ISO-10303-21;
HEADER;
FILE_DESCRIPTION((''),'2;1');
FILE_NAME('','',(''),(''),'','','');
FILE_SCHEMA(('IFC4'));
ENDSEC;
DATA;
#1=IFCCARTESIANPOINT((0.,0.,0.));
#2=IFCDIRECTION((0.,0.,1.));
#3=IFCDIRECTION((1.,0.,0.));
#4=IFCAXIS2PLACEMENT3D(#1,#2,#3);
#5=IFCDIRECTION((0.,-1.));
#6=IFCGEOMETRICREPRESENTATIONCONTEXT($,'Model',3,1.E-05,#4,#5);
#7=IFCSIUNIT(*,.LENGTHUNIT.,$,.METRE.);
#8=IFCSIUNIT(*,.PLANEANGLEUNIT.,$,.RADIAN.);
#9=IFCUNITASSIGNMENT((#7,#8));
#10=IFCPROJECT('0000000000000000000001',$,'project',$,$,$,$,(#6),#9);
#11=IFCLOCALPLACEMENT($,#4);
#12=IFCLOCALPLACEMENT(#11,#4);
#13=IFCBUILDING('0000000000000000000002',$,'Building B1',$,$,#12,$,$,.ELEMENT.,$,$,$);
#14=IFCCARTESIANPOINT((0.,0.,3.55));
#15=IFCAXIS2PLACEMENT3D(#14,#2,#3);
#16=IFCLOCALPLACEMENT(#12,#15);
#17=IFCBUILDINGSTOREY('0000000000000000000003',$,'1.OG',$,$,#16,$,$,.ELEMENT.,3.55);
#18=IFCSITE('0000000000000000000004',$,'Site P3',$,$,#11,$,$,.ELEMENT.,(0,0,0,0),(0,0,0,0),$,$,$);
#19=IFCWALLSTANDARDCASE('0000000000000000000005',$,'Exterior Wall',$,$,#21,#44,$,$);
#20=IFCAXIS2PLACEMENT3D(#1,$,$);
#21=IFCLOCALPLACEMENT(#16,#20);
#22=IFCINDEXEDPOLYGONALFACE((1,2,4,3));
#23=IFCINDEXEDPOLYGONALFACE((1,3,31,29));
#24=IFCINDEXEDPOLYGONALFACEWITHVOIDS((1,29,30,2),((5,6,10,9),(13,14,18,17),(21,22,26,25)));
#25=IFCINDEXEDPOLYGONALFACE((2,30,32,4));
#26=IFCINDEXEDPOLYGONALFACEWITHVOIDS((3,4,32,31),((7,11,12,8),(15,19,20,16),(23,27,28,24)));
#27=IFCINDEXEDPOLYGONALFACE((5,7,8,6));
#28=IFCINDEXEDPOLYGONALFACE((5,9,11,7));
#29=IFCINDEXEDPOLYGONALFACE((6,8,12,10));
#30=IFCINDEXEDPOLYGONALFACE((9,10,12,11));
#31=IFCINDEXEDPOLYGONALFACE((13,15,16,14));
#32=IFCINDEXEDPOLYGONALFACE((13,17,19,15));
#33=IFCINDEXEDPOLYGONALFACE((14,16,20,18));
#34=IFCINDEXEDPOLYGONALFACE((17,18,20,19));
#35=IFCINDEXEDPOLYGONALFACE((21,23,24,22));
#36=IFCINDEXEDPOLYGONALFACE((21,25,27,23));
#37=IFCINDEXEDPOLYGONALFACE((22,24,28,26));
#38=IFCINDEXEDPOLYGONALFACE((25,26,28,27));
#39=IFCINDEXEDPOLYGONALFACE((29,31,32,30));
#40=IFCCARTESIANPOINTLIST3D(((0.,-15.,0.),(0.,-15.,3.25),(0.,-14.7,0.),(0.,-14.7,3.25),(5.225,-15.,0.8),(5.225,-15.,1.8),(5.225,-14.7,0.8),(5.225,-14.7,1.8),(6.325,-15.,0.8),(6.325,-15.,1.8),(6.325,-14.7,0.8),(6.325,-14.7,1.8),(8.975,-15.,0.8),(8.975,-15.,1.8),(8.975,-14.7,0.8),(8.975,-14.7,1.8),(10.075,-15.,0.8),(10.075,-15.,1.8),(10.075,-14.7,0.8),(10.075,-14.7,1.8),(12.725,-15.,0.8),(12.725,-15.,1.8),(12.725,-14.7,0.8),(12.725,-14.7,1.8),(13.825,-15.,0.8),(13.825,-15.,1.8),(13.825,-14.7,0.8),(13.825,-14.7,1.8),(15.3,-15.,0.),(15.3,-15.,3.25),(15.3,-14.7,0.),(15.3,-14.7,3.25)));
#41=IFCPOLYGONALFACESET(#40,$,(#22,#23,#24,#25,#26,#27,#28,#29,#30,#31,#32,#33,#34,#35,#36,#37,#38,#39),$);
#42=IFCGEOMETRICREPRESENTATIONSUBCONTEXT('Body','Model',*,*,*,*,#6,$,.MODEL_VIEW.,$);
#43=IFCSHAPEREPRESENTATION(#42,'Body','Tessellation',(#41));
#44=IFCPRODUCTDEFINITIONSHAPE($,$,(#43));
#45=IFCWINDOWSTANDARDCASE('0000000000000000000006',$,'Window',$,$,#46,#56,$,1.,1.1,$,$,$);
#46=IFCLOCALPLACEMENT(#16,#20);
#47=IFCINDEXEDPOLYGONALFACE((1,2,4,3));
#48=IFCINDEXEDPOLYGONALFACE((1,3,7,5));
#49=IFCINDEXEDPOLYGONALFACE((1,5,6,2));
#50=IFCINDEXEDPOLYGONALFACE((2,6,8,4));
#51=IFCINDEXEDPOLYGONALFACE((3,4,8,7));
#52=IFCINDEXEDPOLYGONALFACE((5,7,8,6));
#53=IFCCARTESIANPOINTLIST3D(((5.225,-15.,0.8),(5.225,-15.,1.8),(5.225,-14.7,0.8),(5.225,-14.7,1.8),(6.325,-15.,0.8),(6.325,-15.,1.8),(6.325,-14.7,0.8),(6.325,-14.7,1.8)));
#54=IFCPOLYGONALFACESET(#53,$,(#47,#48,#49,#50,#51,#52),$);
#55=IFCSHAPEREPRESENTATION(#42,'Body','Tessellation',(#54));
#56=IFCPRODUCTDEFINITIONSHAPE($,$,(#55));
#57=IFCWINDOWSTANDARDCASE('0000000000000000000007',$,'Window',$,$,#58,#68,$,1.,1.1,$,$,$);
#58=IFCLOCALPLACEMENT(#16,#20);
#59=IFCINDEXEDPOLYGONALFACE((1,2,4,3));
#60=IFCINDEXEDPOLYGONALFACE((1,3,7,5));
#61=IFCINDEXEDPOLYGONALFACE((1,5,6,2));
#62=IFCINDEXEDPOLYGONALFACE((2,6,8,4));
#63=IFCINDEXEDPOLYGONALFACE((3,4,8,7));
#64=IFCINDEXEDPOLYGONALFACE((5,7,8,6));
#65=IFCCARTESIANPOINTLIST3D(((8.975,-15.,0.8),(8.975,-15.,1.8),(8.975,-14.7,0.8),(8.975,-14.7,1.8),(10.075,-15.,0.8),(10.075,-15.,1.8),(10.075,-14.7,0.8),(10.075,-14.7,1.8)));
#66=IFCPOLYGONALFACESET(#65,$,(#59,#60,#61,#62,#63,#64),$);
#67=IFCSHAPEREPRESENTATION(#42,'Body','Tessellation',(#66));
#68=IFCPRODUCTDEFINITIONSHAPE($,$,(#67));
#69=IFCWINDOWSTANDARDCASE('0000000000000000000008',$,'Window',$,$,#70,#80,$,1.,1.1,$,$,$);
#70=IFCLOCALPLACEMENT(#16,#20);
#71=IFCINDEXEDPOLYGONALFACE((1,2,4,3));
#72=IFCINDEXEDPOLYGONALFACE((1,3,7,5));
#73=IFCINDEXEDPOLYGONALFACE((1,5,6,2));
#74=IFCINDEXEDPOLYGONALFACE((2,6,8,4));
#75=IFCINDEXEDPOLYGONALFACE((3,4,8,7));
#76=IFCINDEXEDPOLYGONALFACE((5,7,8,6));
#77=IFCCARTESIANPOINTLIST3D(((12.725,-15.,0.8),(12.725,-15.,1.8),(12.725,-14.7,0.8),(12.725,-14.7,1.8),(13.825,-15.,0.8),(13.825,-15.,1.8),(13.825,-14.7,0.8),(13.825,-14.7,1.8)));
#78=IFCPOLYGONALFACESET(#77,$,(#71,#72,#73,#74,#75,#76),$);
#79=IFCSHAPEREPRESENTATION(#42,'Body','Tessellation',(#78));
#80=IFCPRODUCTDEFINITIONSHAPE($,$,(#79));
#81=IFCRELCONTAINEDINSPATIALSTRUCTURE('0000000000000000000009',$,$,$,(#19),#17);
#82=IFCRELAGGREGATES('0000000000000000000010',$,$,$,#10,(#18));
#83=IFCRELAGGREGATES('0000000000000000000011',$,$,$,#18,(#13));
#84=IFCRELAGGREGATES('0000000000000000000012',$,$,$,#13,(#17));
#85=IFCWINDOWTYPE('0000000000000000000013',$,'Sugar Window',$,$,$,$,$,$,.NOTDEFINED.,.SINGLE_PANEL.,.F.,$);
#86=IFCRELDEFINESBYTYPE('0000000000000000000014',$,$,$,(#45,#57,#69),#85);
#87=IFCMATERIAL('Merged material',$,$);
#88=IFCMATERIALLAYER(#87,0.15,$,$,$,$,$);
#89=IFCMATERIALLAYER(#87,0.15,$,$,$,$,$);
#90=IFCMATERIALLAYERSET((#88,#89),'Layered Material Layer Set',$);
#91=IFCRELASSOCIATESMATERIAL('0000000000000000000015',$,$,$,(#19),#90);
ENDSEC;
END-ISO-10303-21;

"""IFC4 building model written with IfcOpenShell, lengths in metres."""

from ifc_helpers import new_model, si_unit, direction, frame, origin_with_axes, place, context, subcontext, project, spatial, polyline, outline, extrude, source, transform, mapped, material, layer, layer_set, layer_usage, type_object, element, fill, save


model = new_model("IFC4")

# Units and contexts
model_context = context("Model", 3, precision=1e-05, world=origin_with_axes(), true_north=direction((0.0, -1.0)))
body_context = subcontext(model_context, "Body", "Model", "MODEL_VIEW")
ifc_project = project(units=[si_unit("LENGTHUNIT", "METRE"), si_unit("PLANEANGLEUNIT", "RADIAN")], contexts=[model_context])

# Site, building, storey
site_placement = place(None, origin_with_axes())
site = spatial("IfcSite", under=ifc_project, at=site_placement, Name="Site P3", CompositionType="ELEMENT", RefLatitude=(0, 0, 0, 0), RefLongitude=(0, 0, 0, 0))
building_placement = place(site_placement, origin_with_axes())
building = spatial("IfcBuilding", under=site, at=building_placement, Name="Building B1", CompositionType="ELEMENT")
storey_placement = place(building_placement, frame((0.0, 0.0, 3.55), z_axis=(0.0, 0.0, 1.0), x_axis=(1.0, 0.0, 0.0)))
storey = spatial("IfcBuildingStorey", under=building, at=storey_placement, Name="1.OG", CompositionType="ELEMENT", Elevation=3.55)

# Wall, openings, windows
ifc_material = material(Name="Merged material")
ifc_layer_1 = layer(ifc_material, 0.15)
ifc_layer_2 = layer(ifc_material, 0.15)
ifc_layer_set_1 = layer_set([ifc_layer_1, ifc_layer_2], Name="Layered Material Layer Set")
ifc_layer_usage_1 = layer_usage(ifc_layer_set_1, "AXIS2", "POSITIVE", -0.15)
wall_1_placement = place(storey_placement, frame((0.0, -14.85, 0.0), z_axis=(0.0, 0.0, 1.0), x_axis=(1.0, 0.0, 0.0)))
wall_1 = element("IfcWallStandardCase", 1, at=wall_1_placement, inside=storey, material=ifc_layer_usage_1, Name="Exterior Wall", context=body_context, shape_type="SweptSolid", body=[
    extrude(outline(polyline([(0.0, 0.15), (15.3, 0.15), (15.3, -0.15), (0.0, -0.15), (0.0, 0.15)])), origin_with_axes(), (0.0, 0.0, 1.0), 3.25),
])
opening_1_placement = place(wall_1_placement, frame((5.225, 0.0, 0.8), z_axis=(0.0, 0.0, 1.0), x_axis=(1.0, 0.0, 0.0)))
opening_1 = element("IfcOpeningStandardCase", 2, at=opening_1_placement, cuts=wall_1, context=body_context, shape_type="SweptSolid", body=[
    extrude(outline(polyline([(0.0, 0.0), (0.0, 1.1), (1.0, 1.1), (1.0, 0.0), (0.0, 0.0)])), frame((0.0, -0.15, 0.0), z_axis=(0.0, 1.0, 0.0), x_axis=(0.0, 0.0, 1.0)), (0.0, 0.0, 1.0), 0.3),
])
opening_2_placement = place(wall_1_placement, frame((8.975, 0.0, 0.8), z_axis=(0.0, 0.0, 1.0), x_axis=(1.0, 0.0, 0.0)))
opening_2 = element("IfcOpeningStandardCase", 3, at=opening_2_placement, cuts=wall_1, context=body_context, shape_type="SweptSolid", body=[
    extrude(outline(polyline([(0.0, 0.0), (0.0, 1.1), (1.0, 1.1), (1.0, 0.0), (0.0, 0.0)])), frame((0.0, -0.15, 0.0), z_axis=(0.0, 1.0, 0.0), x_axis=(0.0, 0.0, 1.0)), (0.0, 0.0, 1.0), 0.3),
])
opening_3_placement = place(wall_1_placement, frame((12.725, 0.0, 0.8), z_axis=(0.0, 0.0, 1.0), x_axis=(1.0, 0.0, 0.0)))
opening_3 = element("IfcOpeningStandardCase", 4, at=opening_3_placement, cuts=wall_1, context=body_context, shape_type="SweptSolid", body=[
    extrude(outline(polyline([(0.0, 0.0), (0.0, 1.1), (1.0, 1.1), (1.0, 0.0), (0.0, 0.0)])), frame((0.0, -0.15, 0.0), z_axis=(0.0, 1.0, 0.0), x_axis=(0.0, 0.0, 1.0)), (0.0, 0.0, 1.0), 0.3),
])
window_type = type_object("IfcWindowType", Name="Sugar Window", ParameterTakesPrecedence=False, PartitioningType="SINGLE_PANEL", PredefinedType="NOTDEFINED")
shared_shape_1 = source(origin_with_axes(), body_context, "Body", "SweptSolid", [
    extrude(outline(polyline([(0.0, 0.0), (0.0, 1.1), (1.0, 1.1), (1.0, 0.0), (0.0, 0.0)])), frame((0.0, -0.15, 0.0), z_axis=(0.0, 1.0, 0.0), x_axis=(0.0, 0.0, 1.0)), (0.0, 0.0, 1.0), 0.3),
])
window_1_placement = place(opening_1_placement, origin_with_axes())
window_1 = element("IfcWindowStandardCase", 5, at=window_1_placement, type_object=window_type, Name="Window", OverallHeight=1.0, OverallWidth=1.1, context=body_context, shape_type="MappedRepresentation", body=[
    mapped(shared_shape_1, transform((0.0, 0.0, 0.0))),
])
fill(opening_1, window_1)
window_2_placement = place(opening_2_placement, origin_with_axes())
window_2 = element("IfcWindowStandardCase", 6, at=window_2_placement, type_object=window_type, Name="Window", OverallHeight=1.0, OverallWidth=1.1, context=body_context, shape_type="MappedRepresentation", body=[
    mapped(shared_shape_1, transform((0.0, 0.0, 0.0))),
])
fill(opening_2, window_2)
window_3_placement = place(opening_3_placement, origin_with_axes())
window_3 = element("IfcWindowStandardCase", 7, at=window_3_placement, type_object=window_type, Name="Window", OverallHeight=1.0, OverallWidth=1.1, context=body_context, shape_type="MappedRepresentation", body=[
    mapped(shared_shape_1, transform((0.0, 0.0, 0.0))),
])
fill(opening_3, window_3)

save(model, "model.ifc")
